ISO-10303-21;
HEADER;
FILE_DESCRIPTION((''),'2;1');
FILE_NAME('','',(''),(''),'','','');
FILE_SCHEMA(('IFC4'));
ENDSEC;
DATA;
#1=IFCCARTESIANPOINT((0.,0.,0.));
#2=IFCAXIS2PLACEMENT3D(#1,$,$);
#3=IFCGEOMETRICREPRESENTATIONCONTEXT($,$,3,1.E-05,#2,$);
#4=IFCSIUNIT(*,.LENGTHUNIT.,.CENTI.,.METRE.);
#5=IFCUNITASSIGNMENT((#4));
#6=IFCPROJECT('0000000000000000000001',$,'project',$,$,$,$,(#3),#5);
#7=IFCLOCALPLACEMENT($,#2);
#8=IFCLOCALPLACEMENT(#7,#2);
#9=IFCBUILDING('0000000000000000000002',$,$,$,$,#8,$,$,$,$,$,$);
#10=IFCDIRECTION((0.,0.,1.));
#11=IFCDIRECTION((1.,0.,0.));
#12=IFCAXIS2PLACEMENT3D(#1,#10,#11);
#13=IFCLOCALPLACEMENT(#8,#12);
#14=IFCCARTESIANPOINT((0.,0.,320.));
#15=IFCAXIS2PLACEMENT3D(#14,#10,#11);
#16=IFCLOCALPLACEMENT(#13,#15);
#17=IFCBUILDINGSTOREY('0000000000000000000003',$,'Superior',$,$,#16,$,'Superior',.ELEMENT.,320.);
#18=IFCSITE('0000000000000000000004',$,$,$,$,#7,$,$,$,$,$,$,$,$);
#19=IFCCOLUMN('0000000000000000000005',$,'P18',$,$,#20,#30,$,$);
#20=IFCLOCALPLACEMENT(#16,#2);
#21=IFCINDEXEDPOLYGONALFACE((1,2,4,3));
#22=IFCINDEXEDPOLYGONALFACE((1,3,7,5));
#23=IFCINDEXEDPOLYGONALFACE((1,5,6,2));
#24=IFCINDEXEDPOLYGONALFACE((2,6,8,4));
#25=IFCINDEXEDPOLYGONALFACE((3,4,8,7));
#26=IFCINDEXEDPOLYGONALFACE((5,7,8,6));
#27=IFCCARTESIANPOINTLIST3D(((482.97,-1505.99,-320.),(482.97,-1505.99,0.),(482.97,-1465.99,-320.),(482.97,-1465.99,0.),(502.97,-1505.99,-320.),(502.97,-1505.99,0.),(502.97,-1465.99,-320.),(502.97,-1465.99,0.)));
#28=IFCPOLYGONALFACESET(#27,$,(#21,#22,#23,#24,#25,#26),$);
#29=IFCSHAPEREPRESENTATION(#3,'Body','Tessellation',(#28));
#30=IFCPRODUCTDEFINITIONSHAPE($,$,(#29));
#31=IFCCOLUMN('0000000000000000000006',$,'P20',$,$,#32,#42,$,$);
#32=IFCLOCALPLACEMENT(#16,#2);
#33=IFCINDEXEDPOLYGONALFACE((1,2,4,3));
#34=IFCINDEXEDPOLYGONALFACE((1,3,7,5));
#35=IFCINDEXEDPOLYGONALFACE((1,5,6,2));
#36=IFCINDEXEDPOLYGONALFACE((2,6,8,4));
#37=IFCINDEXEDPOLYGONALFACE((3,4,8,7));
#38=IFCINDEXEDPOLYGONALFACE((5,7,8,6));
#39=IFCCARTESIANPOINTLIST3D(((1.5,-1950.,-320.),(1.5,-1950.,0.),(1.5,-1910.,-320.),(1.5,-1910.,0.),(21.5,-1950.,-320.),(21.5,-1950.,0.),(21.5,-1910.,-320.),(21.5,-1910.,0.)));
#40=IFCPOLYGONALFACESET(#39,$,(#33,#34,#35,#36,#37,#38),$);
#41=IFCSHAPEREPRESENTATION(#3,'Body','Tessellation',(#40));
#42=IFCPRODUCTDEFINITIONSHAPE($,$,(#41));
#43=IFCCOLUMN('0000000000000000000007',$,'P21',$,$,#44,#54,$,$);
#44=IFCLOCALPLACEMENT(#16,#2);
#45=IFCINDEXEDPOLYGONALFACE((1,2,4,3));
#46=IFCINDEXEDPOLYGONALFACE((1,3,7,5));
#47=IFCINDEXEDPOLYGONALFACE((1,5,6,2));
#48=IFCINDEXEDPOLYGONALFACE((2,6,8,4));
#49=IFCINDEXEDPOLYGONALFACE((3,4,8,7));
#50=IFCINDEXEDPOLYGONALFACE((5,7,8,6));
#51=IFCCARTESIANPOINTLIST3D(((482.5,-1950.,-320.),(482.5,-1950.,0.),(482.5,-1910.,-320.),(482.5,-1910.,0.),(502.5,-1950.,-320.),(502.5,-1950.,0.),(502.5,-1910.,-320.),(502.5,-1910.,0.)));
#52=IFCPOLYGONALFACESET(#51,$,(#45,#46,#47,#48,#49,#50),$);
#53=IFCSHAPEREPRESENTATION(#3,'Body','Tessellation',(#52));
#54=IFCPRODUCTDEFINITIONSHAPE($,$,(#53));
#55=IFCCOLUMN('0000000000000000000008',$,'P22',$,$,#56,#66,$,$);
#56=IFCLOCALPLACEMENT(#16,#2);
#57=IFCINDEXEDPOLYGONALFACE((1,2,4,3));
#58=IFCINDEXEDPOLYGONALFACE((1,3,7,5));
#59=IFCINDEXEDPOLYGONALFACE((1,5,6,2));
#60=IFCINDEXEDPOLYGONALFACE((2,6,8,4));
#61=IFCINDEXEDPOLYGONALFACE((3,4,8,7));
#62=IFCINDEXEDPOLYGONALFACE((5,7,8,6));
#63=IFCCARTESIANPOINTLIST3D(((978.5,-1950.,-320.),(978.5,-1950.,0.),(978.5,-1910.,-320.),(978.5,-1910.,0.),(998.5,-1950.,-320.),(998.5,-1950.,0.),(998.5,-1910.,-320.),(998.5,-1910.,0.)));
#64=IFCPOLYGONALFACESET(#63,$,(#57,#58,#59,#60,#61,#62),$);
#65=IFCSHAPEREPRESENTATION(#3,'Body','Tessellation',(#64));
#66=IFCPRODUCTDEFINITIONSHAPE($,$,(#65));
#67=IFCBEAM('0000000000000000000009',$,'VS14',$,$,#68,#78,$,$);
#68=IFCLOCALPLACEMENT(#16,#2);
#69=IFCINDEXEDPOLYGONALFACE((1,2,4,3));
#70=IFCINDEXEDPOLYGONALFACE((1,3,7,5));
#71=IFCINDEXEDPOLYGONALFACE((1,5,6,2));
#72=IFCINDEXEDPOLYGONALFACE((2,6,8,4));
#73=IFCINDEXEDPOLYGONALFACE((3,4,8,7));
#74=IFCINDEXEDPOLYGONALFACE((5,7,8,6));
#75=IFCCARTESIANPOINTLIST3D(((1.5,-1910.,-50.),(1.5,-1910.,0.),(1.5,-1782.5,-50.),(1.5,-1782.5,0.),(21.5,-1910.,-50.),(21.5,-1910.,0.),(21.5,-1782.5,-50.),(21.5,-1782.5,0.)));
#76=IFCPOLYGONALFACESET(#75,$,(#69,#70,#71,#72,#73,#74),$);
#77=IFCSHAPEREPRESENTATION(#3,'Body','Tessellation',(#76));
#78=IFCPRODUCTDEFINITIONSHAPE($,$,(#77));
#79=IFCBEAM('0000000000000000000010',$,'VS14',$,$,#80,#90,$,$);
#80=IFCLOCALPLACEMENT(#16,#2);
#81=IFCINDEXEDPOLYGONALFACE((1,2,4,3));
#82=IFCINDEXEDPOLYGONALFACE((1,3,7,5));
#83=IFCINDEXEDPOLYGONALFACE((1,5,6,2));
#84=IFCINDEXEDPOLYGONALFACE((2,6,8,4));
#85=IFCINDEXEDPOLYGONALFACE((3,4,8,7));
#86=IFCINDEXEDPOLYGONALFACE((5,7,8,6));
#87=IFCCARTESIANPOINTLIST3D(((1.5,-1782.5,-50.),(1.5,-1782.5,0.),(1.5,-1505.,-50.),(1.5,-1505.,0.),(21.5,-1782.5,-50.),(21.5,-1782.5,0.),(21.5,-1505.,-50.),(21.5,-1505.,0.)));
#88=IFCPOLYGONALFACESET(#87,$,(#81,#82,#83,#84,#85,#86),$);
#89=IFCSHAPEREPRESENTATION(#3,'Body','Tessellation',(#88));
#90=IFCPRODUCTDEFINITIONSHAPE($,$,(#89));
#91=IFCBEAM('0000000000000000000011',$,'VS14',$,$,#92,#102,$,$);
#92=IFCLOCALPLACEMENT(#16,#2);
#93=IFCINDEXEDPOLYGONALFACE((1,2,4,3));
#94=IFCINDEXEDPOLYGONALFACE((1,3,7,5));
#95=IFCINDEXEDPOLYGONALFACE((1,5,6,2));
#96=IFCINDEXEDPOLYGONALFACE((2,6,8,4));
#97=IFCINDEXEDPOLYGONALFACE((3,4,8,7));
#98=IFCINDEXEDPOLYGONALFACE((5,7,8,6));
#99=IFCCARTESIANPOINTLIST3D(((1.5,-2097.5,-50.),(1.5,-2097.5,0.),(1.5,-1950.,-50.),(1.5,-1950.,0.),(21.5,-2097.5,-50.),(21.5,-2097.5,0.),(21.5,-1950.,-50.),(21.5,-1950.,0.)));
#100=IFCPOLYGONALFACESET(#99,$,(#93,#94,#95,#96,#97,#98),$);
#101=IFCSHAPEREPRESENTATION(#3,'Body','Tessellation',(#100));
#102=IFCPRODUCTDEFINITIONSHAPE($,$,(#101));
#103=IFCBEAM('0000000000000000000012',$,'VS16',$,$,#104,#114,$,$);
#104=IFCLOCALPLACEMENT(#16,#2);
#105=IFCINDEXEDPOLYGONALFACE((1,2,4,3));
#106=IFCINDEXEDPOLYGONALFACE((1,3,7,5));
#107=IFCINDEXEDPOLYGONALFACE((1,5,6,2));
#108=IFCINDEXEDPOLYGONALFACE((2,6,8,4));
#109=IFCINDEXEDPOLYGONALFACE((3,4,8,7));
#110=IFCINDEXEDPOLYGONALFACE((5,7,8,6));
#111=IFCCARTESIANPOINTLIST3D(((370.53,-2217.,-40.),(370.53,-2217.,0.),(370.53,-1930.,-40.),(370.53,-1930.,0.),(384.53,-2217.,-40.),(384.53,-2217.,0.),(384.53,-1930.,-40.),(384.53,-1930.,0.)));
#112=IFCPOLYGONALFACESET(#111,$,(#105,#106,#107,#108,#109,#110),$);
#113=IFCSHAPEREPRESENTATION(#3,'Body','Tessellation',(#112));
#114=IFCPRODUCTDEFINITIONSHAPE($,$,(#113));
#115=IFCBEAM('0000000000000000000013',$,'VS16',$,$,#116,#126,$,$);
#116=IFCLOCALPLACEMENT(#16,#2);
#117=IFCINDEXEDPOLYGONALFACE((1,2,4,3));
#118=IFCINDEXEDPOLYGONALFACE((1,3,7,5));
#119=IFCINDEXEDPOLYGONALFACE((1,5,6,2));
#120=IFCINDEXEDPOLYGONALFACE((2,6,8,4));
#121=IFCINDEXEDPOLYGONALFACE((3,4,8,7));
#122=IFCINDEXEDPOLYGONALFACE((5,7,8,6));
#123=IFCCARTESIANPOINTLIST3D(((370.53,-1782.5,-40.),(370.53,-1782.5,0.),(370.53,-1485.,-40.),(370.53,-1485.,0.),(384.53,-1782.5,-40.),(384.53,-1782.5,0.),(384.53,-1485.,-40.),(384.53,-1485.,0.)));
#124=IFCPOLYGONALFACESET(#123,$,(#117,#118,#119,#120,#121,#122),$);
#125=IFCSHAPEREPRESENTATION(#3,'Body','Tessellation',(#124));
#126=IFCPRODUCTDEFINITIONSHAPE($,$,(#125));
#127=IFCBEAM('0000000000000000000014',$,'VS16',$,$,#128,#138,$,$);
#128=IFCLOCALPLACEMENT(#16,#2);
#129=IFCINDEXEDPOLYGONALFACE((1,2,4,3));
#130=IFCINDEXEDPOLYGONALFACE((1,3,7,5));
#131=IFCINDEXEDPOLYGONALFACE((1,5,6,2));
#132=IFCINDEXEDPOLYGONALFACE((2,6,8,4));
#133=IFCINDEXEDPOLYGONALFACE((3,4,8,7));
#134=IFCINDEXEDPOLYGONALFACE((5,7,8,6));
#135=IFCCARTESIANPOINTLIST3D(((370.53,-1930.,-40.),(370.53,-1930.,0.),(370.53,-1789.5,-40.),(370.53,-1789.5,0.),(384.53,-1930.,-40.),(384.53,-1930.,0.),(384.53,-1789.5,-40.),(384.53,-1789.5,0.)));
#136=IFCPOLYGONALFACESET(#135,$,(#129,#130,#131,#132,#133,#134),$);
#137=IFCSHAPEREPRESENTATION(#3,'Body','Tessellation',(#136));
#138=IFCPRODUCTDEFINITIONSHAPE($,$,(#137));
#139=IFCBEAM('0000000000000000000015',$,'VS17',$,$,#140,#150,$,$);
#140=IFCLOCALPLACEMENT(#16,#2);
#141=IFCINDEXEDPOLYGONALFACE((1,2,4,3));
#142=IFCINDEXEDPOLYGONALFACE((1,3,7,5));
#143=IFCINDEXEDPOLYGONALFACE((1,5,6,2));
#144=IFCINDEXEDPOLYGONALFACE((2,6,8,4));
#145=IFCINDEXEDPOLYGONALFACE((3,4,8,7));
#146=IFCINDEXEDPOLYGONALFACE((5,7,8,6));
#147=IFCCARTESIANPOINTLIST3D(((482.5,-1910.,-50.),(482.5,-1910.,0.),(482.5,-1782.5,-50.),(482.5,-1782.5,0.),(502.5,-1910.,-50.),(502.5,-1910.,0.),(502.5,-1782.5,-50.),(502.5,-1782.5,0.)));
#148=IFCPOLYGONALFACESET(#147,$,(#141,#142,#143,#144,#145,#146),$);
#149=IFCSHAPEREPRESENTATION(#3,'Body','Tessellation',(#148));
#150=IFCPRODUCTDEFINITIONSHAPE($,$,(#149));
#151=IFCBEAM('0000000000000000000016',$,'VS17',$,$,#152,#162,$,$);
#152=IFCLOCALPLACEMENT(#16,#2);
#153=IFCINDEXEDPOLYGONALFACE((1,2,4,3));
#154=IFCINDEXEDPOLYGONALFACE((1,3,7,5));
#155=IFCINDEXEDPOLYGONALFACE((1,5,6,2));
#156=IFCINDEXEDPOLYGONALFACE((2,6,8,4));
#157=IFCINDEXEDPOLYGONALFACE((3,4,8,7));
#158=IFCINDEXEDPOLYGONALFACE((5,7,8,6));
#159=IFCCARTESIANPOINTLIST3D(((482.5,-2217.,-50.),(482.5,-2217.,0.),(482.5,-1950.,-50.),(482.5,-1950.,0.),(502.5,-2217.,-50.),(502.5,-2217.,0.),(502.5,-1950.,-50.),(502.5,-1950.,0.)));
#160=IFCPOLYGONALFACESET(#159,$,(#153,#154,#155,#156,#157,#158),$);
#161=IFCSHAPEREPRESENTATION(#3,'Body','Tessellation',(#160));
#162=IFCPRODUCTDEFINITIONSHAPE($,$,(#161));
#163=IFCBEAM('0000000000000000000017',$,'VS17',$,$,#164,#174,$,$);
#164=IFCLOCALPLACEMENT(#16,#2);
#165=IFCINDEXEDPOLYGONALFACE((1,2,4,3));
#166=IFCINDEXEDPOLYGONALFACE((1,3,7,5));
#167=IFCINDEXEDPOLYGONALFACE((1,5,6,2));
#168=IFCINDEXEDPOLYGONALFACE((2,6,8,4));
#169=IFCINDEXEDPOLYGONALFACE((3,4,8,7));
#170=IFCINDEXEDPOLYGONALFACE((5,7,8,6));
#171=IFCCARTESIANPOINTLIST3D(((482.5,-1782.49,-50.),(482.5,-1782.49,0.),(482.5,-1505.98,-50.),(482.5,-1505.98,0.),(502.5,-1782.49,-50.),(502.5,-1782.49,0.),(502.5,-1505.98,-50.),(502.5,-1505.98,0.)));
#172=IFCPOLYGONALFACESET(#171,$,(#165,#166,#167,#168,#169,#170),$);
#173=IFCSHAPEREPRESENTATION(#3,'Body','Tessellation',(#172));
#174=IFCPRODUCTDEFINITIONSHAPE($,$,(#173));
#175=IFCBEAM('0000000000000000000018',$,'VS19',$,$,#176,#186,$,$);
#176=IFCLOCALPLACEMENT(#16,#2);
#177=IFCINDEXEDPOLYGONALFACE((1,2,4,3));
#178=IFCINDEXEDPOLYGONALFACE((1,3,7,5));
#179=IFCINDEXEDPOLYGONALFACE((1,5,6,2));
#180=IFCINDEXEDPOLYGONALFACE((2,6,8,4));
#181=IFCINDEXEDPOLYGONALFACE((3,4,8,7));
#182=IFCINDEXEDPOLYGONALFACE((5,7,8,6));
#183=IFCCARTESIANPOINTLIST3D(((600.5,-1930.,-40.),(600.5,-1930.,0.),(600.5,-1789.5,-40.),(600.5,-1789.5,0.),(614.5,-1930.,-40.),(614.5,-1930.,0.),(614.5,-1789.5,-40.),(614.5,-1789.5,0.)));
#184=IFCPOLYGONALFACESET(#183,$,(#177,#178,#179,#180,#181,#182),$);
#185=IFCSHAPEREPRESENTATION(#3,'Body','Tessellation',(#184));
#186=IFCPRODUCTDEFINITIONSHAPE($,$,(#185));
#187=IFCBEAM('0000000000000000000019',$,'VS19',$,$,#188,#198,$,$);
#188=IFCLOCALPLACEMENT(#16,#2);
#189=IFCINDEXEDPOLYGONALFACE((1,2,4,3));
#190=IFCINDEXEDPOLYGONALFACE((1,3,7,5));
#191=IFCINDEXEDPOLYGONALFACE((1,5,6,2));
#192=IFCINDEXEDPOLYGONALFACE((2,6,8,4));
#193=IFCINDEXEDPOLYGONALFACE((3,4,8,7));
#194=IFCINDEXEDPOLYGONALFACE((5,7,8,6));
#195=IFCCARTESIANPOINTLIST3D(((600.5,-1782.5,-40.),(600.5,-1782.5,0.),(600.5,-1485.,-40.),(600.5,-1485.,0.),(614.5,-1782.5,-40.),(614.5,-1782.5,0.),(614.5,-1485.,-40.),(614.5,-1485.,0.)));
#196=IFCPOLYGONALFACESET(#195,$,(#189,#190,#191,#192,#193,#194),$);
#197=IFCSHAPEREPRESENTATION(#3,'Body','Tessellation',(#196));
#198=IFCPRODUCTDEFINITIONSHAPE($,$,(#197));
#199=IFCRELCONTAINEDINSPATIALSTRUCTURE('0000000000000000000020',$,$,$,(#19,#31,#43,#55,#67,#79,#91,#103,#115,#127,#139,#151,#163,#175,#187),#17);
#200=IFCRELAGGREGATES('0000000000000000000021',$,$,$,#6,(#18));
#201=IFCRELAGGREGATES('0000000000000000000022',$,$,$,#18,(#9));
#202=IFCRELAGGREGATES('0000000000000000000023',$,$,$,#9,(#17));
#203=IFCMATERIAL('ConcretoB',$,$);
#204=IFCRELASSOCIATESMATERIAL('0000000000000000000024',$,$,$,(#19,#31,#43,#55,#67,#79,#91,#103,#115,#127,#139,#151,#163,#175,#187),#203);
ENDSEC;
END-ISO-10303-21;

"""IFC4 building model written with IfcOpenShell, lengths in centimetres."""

from ifc_helpers import new_model, si_unit, frame, origin, origin_with_axes, place, context, project, spatial, polyline, outline, extrude, material, element, save


model = new_model("IFC4")

# Units and contexts
context_of_model = context(None, 3, precision=1e-05, world=origin())
ifc_project = project(units=[si_unit("LENGTHUNIT", "METRE", prefix="CENTI")], contexts=[context_of_model])

# Site, building, storey
site_placement = place(None, origin())
site = spatial("IfcSite", under=ifc_project, at=site_placement)
building_placement = place(site_placement, origin())
building = spatial("IfcBuilding", under=site, at=building_placement)
placement = place(building_placement, origin_with_axes())
storey_placement = place(placement, frame((0.0, 0.0, 320.0), z_axis=(0.0, 0.0, 1.0), x_axis=(1.0, 0.0, 0.0)))
storey = spatial("IfcBuildingStorey", under=building, at=storey_placement, Name="Superior", LongName="Superior", CompositionType="ELEMENT", Elevation=320.0)

# Columns
ifc_material = material(Name="ConcretoB")
column_1_placement = place(storey_placement, frame((492.97, -1485.99, 0.0), z_axis=(0.0, 0.0, 1.0), x_axis=(1.0, 0.0, 0.0)))
element("IfcColumn", 1, at=column_1_placement, inside=storey, material=ifc_material, Name="P18", context=context_of_model, shape_type="SolidModel", body=[
    extrude(outline(polyline([(-10.0, -20.0), (10.0, -20.0), (10.0, 20.0), (-10.0, 20.0), (-10.0, -20.0)])), origin_with_axes(), (0.0, 0.0, -1.0), 320.0),
])
column_2_placement = place(storey_placement, frame((11.5, -1930.0, 0.0), z_axis=(0.0, 0.0, 1.0), x_axis=(1.0, 0.0, 0.0)))
element("IfcColumn", 2, at=column_2_placement, inside=storey, material=ifc_material, Name="P20", context=context_of_model, shape_type="SolidModel", body=[
    extrude(outline(polyline([(-10.0, -20.0), (10.0, -20.0), (10.0, 20.0), (-10.0, 20.0), (-10.0, -20.0)])), frame((0.0, 0.0, 0.0), z_axis=(0.0, 0.0, 1.0), x_axis=(1.0, 0.0, 0.0)), (0.0, 0.0, -1.0), 320.0),
])
column_3_placement = place(storey_placement, frame((492.5, -1930.0, 0.0), z_axis=(0.0, 0.0, 1.0), x_axis=(1.0, 0.0, 0.0)))
element("IfcColumn", 3, at=column_3_placement, inside=storey, material=ifc_material, Name="P21", context=context_of_model, shape_type="SolidModel", body=[
    extrude(outline(polyline([(-10.0, -20.0), (10.0, -20.0), (10.0, 20.0), (-10.0, 20.0), (-10.0, -20.0)])), origin_with_axes(), (0.0, 0.0, -1.0), 320.0),
])
column_4_placement = place(storey_placement, frame((988.5, -1930.0, 0.0), z_axis=(0.0, 0.0, 1.0), x_axis=(1.0, 0.0, 0.0)))
element("IfcColumn", 4, at=column_4_placement, inside=storey, material=ifc_material, Name="P22", context=context_of_model, shape_type="SolidModel", body=[
    extrude(outline(polyline([(10.0, 20.0), (-10.0, 20.0), (-10.0, -20.0), (10.0, -20.0), (10.0, 20.0)])), origin_with_axes(), (0.0, 0.0, -1.0), 320.0),
])

# Beams
beam_1_placement = place(storey_placement, frame((11.5, -1846.25, 0.0), z_axis=(0.0, 0.0, 1.0), x_axis=(1.0, 0.0, 0.0)))
element("IfcBeam", 5, at=beam_1_placement, inside=storey, material=ifc_material, Name="VS14", context=context_of_model, shape_type="SolidModel", body=[
    extrude(outline(polyline([(-10.0, -25.0), (10.0, -25.0), (10.0, 25.0), (-10.0, 25.0), (-10.0, -25.0)])), frame((0.0, -63.75, -25.0), z_axis=(0.0, 1.0, 0.0), x_axis=(1.0, 0.0, 0.0)), (0.0, 0.0, 1.0), 127.5),
])
beam_2_placement = place(storey_placement, frame((11.5, -1643.75, 0.0), z_axis=(0.0, 0.0, 1.0), x_axis=(1.0, 0.0, 0.0)))
element("IfcBeam", 6, at=beam_2_placement, inside=storey, material=ifc_material, Name="VS14", context=context_of_model, shape_type="SolidModel", body=[
    extrude(outline(polyline([(-10.0, -25.0), (10.0, -25.0), (10.0, 25.0), (-10.0, 25.0), (-10.0, -25.0)])), frame((0.0, -138.75, -25.0), z_axis=(0.0, 1.0, 0.0), x_axis=(1.0, 0.0, 0.0)), (0.0, 0.0, 1.0), 277.5),
])
beam_3_placement = place(storey_placement, frame((11.5, -2023.75, 0.0), z_axis=(0.0, 0.0, 1.0), x_axis=(1.0, 0.0, 0.0)))
element("IfcBeam", 7, at=beam_3_placement, inside=storey, material=ifc_material, Name="VS14", context=context_of_model, shape_type="SolidModel", body=[
    extrude(outline(polyline([(-10.0, -25.0), (10.0, -25.0), (10.0, 25.0), (-10.0, 25.0), (-10.0, -25.0)])), frame((0.0, -73.75, -25.0), z_axis=(0.0, 1.0, 0.0), x_axis=(1.0, 0.0, 0.0)), (0.0, 0.0, 1.0), 147.5),
])
beam_4_placement = place(storey_placement, frame((377.53, -2073.5, 0.0), z_axis=(0.0, 0.0, 1.0), x_axis=(1.0, 0.0, 0.0)))
element("IfcBeam", 8, at=beam_4_placement, inside=storey, material=ifc_material, Name="VS16", context=context_of_model, shape_type="SolidModel", body=[
    extrude(outline(polyline([(-7.0, -20.0), (7.0, -20.0), (7.0, 20.0), (-7.0, 20.0), (-7.0, -20.0)])), frame((0.0, -143.5, -20.0), z_axis=(0.0, 1.0, 0.0), x_axis=(1.0, 0.0, 0.0)), (0.0, 0.0, 1.0), 287.0),
])
beam_5_placement = place(storey_placement, frame((377.53, -1633.75, 0.0), z_axis=(0.0, 0.0, 1.0), x_axis=(1.0, 0.0, 0.0)))
element("IfcBeam", 9, at=beam_5_placement, inside=storey, material=ifc_material, Name="VS16", context=context_of_model, shape_type="SolidModel", body=[
    extrude(outline(polyline([(-7.0, -20.0), (7.0, -20.0), (7.0, 20.0), (-7.0, 20.0), (-7.0, -20.0)])), frame((0.0, -148.75, -20.0), z_axis=(0.0, 1.0, 0.0), x_axis=(1.0, 0.0, 0.0)), (0.0, 0.0, 1.0), 297.5),
])
beam_6_placement = place(storey_placement, frame((377.53, -1859.75, 0.0), z_axis=(0.0, 0.0, 1.0), x_axis=(1.0, 0.0, 0.0)))
element("IfcBeam", 10, at=beam_6_placement, inside=storey, material=ifc_material, Name="VS16", context=context_of_model, shape_type="SolidModel", body=[
    extrude(outline(polyline([(-7.0, -20.0), (7.0, -20.0), (7.0, 20.0), (-7.0, 20.0), (-7.0, -20.0)])), frame((0.0, -70.25, -20.0), z_axis=(0.0, 1.0, 0.0), x_axis=(1.0, 0.0, 0.0)), (0.0, 0.0, 1.0), 140.5),
])
beam_7_placement = place(storey_placement, frame((492.5, -1846.25, 0.0), z_axis=(0.0, 0.0, 1.0), x_axis=(1.0, 0.0, 0.0)))
element("IfcBeam", 11, at=beam_7_placement, inside=storey, material=ifc_material, Name="VS17", context=context_of_model, shape_type="SolidModel", body=[
    extrude(outline(polyline([(-10.0, -25.0), (10.0, -25.0), (10.0, 25.0), (-10.0, 25.0), (-10.0, -25.0)])), frame((0.0, -63.75, -25.0), z_axis=(0.0, 1.0, 0.0), x_axis=(1.0, 0.0, 0.0)), (0.0, 0.0, 1.0), 127.5),
])
beam_8_placement = place(storey_placement, frame((492.5, -2083.5, 0.0), z_axis=(0.0, 0.0, 1.0), x_axis=(1.0, 0.0, 0.0)))
element("IfcBeam", 12, at=beam_8_placement, inside=storey, material=ifc_material, Name="VS17", context=context_of_model, shape_type="SolidModel", body=[
    extrude(outline(polyline([(-10.0, -25.0), (10.0, -25.0), (10.0, 25.0), (-10.0, 25.0), (-10.0, -25.0)])), frame((0.0, -133.5, -25.0), z_axis=(0.0, 1.0, 0.0), x_axis=(1.0, 0.0, 0.0)), (0.0, 0.0, 1.0), 267.0),
])
beam_9_placement = place(storey_placement, frame((492.5, -1644.24, 0.0), z_axis=(0.0, 0.0, 1.0), x_axis=(1.0, 0.0, 0.0)))
element("IfcBeam", 13, at=beam_9_placement, inside=storey, material=ifc_material, Name="VS17", context=context_of_model, shape_type="SolidModel", body=[
    extrude(outline(polyline([(-10.0, -25.0), (10.0, -25.0), (10.0, 25.0), (-10.0, 25.0), (-10.0, -25.0)])), frame((0.0, -138.25, -25.0), z_axis=(0.0, 1.0, 0.0), x_axis=(1.0, 0.0, 0.0)), (0.0, 0.0, 1.0), 276.51),
])
beam_10_placement = place(storey_placement, frame((607.5, -1859.75, 0.0), z_axis=(0.0, 0.0, 1.0), x_axis=(1.0, 0.0, 0.0)))
element("IfcBeam", 14, at=beam_10_placement, inside=storey, material=ifc_material, Name="VS19", context=context_of_model, shape_type="SolidModel", body=[
    extrude(outline(polyline([(-7.0, -20.0), (7.0, -20.0), (7.0, 20.0), (-7.0, 20.0), (-7.0, -20.0)])), frame((0.0, -70.25, -20.0), z_axis=(0.0, 1.0, 0.0), x_axis=(1.0, 0.0, 0.0)), (0.0, 0.0, 1.0), 140.5),
])
beam_11_placement = place(storey_placement, frame((607.5, -1633.75, 0.0), z_axis=(0.0, 0.0, 1.0), x_axis=(1.0, 0.0, 0.0)))
element("IfcBeam", 15, at=beam_11_placement, inside=storey, material=ifc_material, Name="VS19", context=context_of_model, shape_type="SolidModel", body=[
    extrude(outline(polyline([(-7.0, -20.0), (7.0, -20.0), (7.0, 20.0), (-7.0, 20.0), (-7.0, -20.0)])), frame((0.0, -148.75, -20.0), z_axis=(0.0, 1.0, 0.0), x_axis=(1.0, 0.0, 0.0)), (0.0, 0.0, 1.0), 297.5),
])

save(model, "model.ifc")
